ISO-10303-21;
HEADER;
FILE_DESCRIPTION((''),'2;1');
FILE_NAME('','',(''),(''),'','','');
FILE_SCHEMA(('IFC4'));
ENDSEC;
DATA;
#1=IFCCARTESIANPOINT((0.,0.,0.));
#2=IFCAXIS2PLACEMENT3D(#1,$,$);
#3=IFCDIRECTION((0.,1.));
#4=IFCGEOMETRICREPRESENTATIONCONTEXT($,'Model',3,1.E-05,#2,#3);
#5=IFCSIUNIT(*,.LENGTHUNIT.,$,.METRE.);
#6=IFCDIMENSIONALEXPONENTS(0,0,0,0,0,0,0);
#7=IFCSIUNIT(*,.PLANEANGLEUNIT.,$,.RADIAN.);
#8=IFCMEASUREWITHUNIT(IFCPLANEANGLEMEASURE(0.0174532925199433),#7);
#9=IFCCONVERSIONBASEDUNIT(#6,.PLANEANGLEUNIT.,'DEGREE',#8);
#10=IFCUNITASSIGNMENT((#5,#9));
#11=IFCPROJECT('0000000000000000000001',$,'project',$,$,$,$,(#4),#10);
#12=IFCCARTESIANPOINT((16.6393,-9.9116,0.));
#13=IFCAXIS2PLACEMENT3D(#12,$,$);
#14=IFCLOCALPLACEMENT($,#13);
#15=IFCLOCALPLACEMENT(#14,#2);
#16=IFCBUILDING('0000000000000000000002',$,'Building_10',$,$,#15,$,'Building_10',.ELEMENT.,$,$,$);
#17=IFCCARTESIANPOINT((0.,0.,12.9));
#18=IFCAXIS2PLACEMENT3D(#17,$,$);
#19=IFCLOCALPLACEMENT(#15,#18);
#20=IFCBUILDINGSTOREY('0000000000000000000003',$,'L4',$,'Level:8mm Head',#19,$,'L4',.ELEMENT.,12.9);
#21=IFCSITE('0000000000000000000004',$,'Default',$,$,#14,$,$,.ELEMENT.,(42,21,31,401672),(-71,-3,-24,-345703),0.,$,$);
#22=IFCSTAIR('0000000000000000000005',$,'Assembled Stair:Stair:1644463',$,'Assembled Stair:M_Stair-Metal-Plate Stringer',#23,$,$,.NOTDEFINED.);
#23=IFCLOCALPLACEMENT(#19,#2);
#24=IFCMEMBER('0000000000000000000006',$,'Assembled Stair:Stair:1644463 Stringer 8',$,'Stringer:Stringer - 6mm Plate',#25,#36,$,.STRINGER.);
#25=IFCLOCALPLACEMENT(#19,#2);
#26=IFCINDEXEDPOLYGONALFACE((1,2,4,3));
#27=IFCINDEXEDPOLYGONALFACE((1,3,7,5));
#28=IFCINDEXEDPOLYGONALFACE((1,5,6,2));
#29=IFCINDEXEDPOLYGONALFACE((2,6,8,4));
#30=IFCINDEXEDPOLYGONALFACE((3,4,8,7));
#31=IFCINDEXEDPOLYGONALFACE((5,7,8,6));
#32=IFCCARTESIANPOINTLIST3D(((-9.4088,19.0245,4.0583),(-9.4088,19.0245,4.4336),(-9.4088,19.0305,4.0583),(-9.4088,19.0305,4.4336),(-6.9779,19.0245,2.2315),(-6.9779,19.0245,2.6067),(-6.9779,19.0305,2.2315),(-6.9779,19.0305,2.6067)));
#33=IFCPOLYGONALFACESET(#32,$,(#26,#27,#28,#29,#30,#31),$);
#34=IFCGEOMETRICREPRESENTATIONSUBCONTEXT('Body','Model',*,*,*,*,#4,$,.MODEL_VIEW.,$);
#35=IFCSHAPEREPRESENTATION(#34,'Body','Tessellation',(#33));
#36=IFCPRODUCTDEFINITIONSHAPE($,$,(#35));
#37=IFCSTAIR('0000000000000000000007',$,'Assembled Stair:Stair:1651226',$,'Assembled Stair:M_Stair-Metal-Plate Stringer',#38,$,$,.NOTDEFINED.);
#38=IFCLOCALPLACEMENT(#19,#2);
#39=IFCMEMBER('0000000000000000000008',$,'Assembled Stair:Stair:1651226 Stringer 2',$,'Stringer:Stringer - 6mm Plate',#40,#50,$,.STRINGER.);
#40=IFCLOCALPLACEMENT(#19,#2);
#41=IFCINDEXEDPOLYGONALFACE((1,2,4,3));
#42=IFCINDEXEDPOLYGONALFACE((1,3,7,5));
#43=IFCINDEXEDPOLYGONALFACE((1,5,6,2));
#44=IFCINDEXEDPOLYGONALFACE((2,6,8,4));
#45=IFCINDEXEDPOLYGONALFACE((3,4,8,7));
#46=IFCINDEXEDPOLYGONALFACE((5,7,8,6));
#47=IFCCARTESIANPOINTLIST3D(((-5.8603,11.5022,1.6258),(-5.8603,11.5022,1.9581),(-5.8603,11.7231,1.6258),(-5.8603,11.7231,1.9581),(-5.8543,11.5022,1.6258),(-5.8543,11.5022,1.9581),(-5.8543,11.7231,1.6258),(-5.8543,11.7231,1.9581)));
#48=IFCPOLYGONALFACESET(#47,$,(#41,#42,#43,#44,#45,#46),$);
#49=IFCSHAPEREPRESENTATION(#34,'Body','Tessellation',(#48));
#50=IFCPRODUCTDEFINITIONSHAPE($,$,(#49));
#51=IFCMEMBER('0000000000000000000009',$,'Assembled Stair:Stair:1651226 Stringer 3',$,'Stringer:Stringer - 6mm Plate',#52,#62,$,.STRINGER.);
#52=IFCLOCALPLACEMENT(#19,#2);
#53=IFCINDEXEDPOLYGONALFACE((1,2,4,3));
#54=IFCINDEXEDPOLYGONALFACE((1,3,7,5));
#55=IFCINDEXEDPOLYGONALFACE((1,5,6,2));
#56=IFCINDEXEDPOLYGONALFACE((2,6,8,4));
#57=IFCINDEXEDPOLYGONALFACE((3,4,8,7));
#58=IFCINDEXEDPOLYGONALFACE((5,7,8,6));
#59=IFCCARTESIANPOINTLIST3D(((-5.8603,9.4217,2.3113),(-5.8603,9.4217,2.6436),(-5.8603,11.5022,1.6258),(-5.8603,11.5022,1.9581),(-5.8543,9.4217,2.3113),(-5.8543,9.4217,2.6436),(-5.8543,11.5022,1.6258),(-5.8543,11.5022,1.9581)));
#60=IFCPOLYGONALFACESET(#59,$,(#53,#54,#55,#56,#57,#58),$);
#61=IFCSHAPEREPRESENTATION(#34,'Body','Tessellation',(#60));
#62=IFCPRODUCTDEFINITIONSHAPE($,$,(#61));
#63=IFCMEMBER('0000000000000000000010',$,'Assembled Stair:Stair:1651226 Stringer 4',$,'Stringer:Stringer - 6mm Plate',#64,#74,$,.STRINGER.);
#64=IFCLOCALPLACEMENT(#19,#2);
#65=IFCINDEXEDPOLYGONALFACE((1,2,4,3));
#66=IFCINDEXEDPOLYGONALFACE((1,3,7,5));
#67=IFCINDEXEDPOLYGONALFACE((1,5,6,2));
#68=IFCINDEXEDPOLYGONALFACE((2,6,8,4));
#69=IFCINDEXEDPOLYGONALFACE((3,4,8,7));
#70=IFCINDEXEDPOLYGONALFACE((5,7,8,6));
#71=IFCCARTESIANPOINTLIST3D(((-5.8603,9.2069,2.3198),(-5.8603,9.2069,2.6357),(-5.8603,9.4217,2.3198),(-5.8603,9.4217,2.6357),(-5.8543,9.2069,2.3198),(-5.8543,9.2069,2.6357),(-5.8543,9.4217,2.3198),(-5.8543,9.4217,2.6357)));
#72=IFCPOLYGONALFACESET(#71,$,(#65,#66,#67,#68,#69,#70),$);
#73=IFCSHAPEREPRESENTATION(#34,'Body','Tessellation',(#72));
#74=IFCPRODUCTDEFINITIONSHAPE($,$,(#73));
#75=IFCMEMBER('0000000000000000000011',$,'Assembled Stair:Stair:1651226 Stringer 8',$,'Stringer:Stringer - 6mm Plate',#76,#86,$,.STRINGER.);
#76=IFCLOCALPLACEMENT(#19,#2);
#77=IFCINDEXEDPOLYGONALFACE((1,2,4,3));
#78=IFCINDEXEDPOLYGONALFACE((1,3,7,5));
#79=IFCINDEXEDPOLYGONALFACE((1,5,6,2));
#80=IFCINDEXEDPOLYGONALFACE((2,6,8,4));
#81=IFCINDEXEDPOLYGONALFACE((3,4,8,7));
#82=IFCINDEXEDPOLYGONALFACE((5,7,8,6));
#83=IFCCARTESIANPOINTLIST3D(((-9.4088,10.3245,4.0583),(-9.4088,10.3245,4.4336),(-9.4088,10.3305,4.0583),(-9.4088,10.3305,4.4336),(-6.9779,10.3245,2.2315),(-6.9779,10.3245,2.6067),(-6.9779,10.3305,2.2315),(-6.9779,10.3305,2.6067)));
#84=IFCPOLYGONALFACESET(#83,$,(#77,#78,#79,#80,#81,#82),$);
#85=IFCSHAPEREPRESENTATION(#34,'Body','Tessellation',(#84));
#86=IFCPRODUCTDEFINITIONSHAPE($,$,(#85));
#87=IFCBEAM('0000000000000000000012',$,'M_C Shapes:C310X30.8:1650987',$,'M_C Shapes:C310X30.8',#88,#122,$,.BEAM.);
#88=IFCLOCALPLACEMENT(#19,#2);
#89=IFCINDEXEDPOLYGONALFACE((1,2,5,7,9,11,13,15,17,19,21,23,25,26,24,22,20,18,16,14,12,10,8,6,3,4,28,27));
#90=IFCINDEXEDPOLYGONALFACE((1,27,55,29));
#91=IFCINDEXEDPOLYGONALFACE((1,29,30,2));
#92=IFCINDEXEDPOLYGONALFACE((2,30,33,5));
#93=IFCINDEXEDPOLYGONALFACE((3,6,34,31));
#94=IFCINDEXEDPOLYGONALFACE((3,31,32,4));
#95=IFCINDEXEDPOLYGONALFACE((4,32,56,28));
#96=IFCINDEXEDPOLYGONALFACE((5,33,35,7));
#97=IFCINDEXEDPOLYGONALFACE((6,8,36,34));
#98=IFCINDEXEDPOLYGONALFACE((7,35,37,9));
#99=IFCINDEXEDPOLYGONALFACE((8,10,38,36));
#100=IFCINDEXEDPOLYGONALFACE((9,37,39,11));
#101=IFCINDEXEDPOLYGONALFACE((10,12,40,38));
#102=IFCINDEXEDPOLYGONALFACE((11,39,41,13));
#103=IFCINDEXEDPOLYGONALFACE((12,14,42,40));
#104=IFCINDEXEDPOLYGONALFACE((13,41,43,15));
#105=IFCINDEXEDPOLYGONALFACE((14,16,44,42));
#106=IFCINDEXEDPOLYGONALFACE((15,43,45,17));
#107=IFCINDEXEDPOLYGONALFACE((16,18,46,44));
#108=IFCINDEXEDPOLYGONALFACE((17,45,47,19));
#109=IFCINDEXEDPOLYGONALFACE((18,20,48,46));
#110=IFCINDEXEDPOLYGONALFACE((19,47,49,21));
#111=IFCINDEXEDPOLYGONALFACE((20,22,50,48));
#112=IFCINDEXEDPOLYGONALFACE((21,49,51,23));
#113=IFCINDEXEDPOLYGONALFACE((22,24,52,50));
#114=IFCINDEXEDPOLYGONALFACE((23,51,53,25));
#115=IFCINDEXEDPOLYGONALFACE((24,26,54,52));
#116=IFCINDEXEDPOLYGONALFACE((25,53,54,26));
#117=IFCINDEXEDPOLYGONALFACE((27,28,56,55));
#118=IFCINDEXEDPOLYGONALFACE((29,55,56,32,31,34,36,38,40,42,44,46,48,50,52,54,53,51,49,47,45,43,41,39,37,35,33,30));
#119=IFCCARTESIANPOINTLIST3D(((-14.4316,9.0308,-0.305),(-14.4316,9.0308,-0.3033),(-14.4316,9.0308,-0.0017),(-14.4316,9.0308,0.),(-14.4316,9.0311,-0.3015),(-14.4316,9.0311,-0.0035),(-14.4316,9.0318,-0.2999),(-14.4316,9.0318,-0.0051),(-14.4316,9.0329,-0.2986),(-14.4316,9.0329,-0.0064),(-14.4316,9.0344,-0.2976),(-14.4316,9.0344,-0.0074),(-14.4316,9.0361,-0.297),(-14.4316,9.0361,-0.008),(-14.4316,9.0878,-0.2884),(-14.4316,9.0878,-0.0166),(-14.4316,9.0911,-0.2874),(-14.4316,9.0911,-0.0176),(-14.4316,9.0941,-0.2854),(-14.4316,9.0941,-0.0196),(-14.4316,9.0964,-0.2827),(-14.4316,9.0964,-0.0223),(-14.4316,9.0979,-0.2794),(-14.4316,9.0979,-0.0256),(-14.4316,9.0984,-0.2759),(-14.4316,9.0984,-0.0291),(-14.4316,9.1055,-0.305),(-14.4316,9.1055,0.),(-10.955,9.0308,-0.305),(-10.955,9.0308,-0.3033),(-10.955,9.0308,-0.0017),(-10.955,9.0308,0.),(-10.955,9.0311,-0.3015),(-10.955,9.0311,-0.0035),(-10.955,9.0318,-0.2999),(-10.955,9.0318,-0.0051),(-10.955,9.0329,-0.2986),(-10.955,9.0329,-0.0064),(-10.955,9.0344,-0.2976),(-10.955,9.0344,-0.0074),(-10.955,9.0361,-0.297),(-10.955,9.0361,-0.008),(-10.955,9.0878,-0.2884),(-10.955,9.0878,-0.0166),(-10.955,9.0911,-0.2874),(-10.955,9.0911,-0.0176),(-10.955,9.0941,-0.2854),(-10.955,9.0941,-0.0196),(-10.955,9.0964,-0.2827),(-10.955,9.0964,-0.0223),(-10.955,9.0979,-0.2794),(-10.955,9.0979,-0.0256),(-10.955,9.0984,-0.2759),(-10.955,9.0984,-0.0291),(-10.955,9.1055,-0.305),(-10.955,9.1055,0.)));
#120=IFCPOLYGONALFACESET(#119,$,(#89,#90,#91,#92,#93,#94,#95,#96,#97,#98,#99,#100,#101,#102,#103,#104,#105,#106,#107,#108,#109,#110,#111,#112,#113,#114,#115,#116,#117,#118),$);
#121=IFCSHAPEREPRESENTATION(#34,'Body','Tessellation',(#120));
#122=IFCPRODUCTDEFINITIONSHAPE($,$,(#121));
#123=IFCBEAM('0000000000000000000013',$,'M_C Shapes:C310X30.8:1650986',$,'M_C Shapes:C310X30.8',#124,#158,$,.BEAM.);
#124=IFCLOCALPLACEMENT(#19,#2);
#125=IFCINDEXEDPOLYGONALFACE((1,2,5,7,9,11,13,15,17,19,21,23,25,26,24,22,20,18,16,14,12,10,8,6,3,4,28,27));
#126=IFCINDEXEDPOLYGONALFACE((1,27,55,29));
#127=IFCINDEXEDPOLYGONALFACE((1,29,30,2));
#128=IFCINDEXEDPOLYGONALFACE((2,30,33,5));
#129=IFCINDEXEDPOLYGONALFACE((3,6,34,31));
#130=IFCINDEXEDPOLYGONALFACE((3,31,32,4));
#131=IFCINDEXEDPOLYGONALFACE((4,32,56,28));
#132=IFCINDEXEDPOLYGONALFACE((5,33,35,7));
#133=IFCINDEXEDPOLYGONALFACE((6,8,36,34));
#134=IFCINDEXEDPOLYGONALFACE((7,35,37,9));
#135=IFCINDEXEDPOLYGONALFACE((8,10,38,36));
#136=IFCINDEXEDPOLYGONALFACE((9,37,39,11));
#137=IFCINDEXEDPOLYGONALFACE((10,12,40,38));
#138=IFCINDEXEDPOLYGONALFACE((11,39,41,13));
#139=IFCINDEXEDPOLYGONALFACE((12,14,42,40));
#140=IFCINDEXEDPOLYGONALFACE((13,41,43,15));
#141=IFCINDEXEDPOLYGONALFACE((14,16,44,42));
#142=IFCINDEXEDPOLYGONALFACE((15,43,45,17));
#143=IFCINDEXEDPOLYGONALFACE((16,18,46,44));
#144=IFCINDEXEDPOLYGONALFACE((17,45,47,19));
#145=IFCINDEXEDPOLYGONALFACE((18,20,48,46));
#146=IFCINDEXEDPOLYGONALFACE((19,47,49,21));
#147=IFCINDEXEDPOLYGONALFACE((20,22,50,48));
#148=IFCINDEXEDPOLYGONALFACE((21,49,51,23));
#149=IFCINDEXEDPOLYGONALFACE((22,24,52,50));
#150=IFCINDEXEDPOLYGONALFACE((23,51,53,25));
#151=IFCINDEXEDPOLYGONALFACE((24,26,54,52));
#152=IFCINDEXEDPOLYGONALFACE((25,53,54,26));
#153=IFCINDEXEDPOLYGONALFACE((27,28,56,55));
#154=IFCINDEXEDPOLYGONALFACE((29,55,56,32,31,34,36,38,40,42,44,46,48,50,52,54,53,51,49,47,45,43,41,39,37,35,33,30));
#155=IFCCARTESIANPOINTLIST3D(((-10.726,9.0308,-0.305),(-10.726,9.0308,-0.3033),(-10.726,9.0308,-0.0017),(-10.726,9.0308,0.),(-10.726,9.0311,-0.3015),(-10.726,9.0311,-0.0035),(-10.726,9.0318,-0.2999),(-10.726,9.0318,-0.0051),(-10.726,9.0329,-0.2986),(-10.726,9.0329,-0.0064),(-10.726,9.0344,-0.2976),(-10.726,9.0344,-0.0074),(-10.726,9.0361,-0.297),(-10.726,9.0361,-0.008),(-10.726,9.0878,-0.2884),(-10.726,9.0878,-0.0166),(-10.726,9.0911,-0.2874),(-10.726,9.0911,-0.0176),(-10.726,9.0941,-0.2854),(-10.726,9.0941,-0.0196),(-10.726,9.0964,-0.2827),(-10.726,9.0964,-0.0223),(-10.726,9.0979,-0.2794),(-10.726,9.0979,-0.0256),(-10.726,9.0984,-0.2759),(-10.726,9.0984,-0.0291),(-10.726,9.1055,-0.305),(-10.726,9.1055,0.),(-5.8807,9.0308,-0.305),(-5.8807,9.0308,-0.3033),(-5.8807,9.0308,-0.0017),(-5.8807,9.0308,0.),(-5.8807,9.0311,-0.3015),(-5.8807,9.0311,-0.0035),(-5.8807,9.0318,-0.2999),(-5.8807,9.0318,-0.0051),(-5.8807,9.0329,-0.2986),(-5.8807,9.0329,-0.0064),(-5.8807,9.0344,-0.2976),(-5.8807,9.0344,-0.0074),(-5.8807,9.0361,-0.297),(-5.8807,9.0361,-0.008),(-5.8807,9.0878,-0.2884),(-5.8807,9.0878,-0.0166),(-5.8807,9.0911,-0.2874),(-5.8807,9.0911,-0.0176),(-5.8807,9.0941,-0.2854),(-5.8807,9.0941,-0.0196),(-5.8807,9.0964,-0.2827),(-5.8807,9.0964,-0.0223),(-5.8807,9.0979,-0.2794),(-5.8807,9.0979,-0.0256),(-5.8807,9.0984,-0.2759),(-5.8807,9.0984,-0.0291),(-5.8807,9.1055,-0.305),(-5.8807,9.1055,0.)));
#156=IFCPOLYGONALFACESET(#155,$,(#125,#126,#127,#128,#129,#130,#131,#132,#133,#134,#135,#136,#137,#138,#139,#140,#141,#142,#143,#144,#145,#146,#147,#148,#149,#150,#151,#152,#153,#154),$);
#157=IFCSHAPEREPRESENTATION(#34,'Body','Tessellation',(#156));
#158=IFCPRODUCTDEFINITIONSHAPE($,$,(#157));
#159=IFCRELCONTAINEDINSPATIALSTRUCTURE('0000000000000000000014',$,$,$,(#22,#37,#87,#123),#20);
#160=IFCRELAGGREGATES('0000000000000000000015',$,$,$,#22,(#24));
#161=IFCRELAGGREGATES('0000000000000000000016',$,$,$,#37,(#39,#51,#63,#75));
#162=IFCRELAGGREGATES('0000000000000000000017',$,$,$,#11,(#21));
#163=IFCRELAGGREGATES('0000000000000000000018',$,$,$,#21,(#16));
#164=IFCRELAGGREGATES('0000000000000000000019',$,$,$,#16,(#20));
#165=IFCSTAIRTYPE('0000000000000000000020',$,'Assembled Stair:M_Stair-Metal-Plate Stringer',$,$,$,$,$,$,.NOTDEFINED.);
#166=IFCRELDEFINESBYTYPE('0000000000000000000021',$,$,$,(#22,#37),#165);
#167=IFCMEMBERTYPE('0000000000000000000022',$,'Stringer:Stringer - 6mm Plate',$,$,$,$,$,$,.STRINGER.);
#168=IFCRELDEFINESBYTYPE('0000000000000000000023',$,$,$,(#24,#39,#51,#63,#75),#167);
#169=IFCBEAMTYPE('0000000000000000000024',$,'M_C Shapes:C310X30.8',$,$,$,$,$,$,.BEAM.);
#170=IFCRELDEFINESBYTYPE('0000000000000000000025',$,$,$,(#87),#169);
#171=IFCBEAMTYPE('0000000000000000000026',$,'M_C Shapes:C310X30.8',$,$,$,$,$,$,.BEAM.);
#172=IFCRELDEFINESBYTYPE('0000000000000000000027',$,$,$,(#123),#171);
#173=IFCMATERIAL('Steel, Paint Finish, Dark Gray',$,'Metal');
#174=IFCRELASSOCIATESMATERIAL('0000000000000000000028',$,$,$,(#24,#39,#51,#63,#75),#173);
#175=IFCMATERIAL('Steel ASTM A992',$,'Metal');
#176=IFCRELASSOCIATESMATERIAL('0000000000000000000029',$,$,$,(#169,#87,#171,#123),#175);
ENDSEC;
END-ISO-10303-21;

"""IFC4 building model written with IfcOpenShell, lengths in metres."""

from ifc_helpers import new_model, entity, si_unit, converted_unit, direction, frame, origin, place, context, subcontext, project, spatial, line, arc, indexed_curve, outline, extrude, source, transform, mapped, material, type_object, type_shapes, element, aggregate, save


model = new_model("IFC4")

# Units and contexts
model_context = context("Model", 3, precision=1e-05, world=origin(), true_north=direction((0.0, 1.0)))
body_context = subcontext(model_context, "Body", "Model", "MODEL_VIEW")
ifc_project = project(units=[si_unit("LENGTHUNIT", "METRE"), converted_unit("PLANEANGLEUNIT", "DEGREE", entity("IfcPlaneAngleMeasure", 0.0174532925199433), si_unit("PLANEANGLEUNIT", "RADIAN"), dimensions=[0, 0, 0, 0, 0, 0, 0])], contexts=[model_context])

# Site, building, storey
site_placement = place(None, frame((16.6393, -9.9116, 0.0)))
site = spatial("IfcSite", under=ifc_project, at=site_placement, Name="Default", CompositionType="ELEMENT", RefLatitude=(42, 21, 31, 401672), RefLongitude=(-71, -3, -24, -345703), RefElevation=0.0)
building_placement = place(site_placement, origin())
building = spatial("IfcBuilding", under=site, at=building_placement, Name="Building_10", LongName="Building_10", CompositionType="ELEMENT")
storey_placement = place(building_placement, frame((0.0, 0.0, 12.9)))
storey = spatial("IfcBuildingStorey", under=building, at=storey_placement, Name="L4", ObjectType="Level:8mm Head", LongName="L4", CompositionType="ELEMENT", Elevation=12.9)

# Shared definitions
ifc_material_1 = material(Name="Steel ASTM A992", Category="Metal")

# Stairs, members
stair_type = type_object("IfcStairType", Name="Assembled Stair:M_Stair-Metal-Plate Stringer", PredefinedType="NOTDEFINED")
stair_1_placement = place(storey_placement, origin())
stair_1 = element("IfcStair", 1, at=stair_1_placement, inside=storey, type_object=stair_type, Name="Assembled Stair:Stair:1644463", ObjectType="Assembled Stair:M_Stair-Metal-Plate Stringer", PredefinedType="NOTDEFINED")
ifc_material_2 = material(Name="Steel, Paint Finish, Dark Gray", Category="Metal")
member_type = type_object("IfcMemberType", Name="Stringer:Stringer - 6mm Plate", PredefinedType="STRINGER")
member_1_placement = place(stair_1_placement, origin())
member_1 = element("IfcMember", 2, at=member_1_placement, type_object=member_type, material=ifc_material_2, Name="Assembled Stair:Stair:1644463 Stringer 8", ObjectType="Stringer:Stringer - 6mm Plate", PredefinedType="STRINGER", context=body_context, shape_type="SweptSolid", body=[
    extrude(outline(indexed_curve([(-1.6331, -0.15), (1.4077, -0.15), (1.6331, 0.15), (-1.4077, 0.15), (-1.6331, -0.15)], self_intersect=False)), frame((-8.1933, 19.0245, 3.3325), z_axis=(0.0, 1.0, 0.0), x_axis=(-0.799415, 0.0, 0.600779)), (0.0, 0.0, 1.0), 0.006),
])
aggregate(stair_1, [member_1])
stair_2_placement = place(storey_placement, origin())
stair_2 = element("IfcStair", 3, at=stair_2_placement, inside=storey, type_object=stair_type, Name="Assembled Stair:Stair:1651226", ObjectType="Assembled Stair:M_Stair-Metal-Plate Stringer", PredefinedType="NOTDEFINED")
member_2_placement = place(stair_2_placement, origin())
member_2 = element("IfcMember", 4, at=member_2_placement, type_object=member_type, material=ifc_material_2, Name="Assembled Stair:Stair:1651226 Stringer 2", ObjectType="Stringer:Stringer - 6mm Plate", PredefinedType="STRINGER", context=body_context, shape_type="SweptSolid", body=[
    extrude(outline(indexed_curve([(-0.1104, -0.003), (0.1104, -0.003), (0.1104, 0.003), (-0.1104, 0.003), (-0.1104, -0.003)], self_intersect=False)), frame((-5.8573, 11.6126, 1.6258), z_axis=(0.0, 0.0, 1.0), x_axis=(0.0, -1.0, 0.0)), (0.0, 0.0, 1.0), 0.3323),
])
member_3_placement = place(stair_2_placement, origin())
member_3 = element("IfcMember", 5, at=member_3_placement, type_object=member_type, material=ifc_material_2, Name="Assembled Stair:Stair:1651226 Stringer 3", ObjectType="Stringer:Stringer - 6mm Plate", PredefinedType="STRINGER", context=body_context, shape_type="SweptSolid", body=[
    extrude(outline(indexed_curve([(-1.0433, -0.1578), (1.1473, -0.1578), (1.0433, 0.1578), (-1.1473, 0.1578), (-1.0433, -0.1578)], self_intersect=False)), frame((-5.8603, 10.462, 2.1347), z_axis=(1.0, 0.0, 0.0), x_axis=(0.0, -0.949774, 0.312936)), (0.0, 0.0, 1.0), 0.006),
])
member_4_placement = place(stair_2_placement, origin())
member_4 = element("IfcMember", 6, at=member_4_placement, type_object=member_type, material=ifc_material_2, Name="Assembled Stair:Stair:1651226 Stringer 4", ObjectType="Stringer:Stringer - 6mm Plate", PredefinedType="STRINGER", context=body_context, shape_type="SweptSolid", body=[
    extrude(outline(indexed_curve([(-0.1074, -0.003), (0.1074, -0.003), (0.1074, 0.003), (-0.1074, 0.003), (-0.1074, -0.003)], self_intersect=False)), frame((-5.8573, 9.3143, 2.3198), z_axis=(0.0, 0.0, 1.0), x_axis=(0.0, -1.0, 0.0)), (0.0, 0.0, 1.0), 0.3159),
])
member_5_placement = place(stair_2_placement, origin())
member_5 = element("IfcMember", 7, at=member_5_placement, type_object=member_type, material=ifc_material_2, Name="Assembled Stair:Stair:1651226 Stringer 8", ObjectType="Stringer:Stringer - 6mm Plate", PredefinedType="STRINGER", context=body_context, shape_type="SweptSolid", body=[
    extrude(outline(indexed_curve([(-1.6331, -0.15), (1.4077, -0.15), (1.6331, 0.15), (-1.4077, 0.15), (-1.6331, -0.15)], self_intersect=False)), frame((-8.1933, 10.3245, 3.3325), z_axis=(0.0, 1.0, 0.0), x_axis=(-0.799415, 0.0, 0.600779)), (0.0, 0.0, 1.0), 0.006),
])
aggregate(stair_2, [member_2, member_3, member_4, member_5])

# Beams
beam_type_1 = type_object("IfcBeamType", Name="M_C Shapes:C310X30.8", PredefinedType="BEAM", material=ifc_material_1)
shared_shape_1 = source(origin(), body_context, "Body", "SweptSolid", [
    extrude(outline(indexed_curve([(-0.0406, -0.1525), (0.0341, -0.1525), (0.0341, -0.1508), (0.0326, -0.1467), (0.0288, -0.1445), (-0.0228, -0.1359), (-0.0305, -0.1316), (-0.0335, -0.1234), (-0.0335, 0.1234), (-0.0305, 0.1316), (-0.0228, 0.1359), (0.0288, 0.1445), (0.0326, 0.1467), (0.0341, 0.1508), (0.0341, 0.1525), (-0.0406, 0.1525)], segments=[line(1, 2, 3), arc(3, 4, 5), line(5, 6), arc(6, 7, 8), line(8, 9), arc(9, 10, 11), line(11, 12), arc(12, 13, 14), line(14, 15, 16, 1)], self_intersect=False)), frame((-1.7383, -0.0229, 0.0), z_axis=(1.0, 0.0, 0.0), x_axis=(0.0, -1.0, 0.0)), (0.0, 0.0, 1.0), 3.4766),
])
type_shapes(beam_type_1, [shared_shape_1])
beam_1_placement = place(storey_placement, frame((-12.6933, 9.0878, -0.1525)))
element("IfcBeam", 8, at=beam_1_placement, inside=storey, type_object=beam_type_1, material=ifc_material_1, Name="M_C Shapes:C310X30.8:1650987", ObjectType="M_C Shapes:C310X30.8", PredefinedType="BEAM", context=body_context, shape_type="MappedRepresentation", body=[
    mapped(shared_shape_1, transform((0.0, 0.0, 0.0), scale=1.0)),
])
beam_type_2 = type_object("IfcBeamType", Name="M_C Shapes:C310X30.8", PredefinedType="BEAM", material=ifc_material_1)
shared_shape_2 = source(origin(), body_context, "Body", "SweptSolid", [
    extrude(outline(indexed_curve([(-0.0406, -0.1525), (0.0341, -0.1525), (0.0341, -0.1508), (0.0326, -0.1467), (0.0288, -0.1445), (-0.0228, -0.1359), (-0.0305, -0.1316), (-0.0335, -0.1234), (-0.0335, 0.1234), (-0.0305, 0.1316), (-0.0228, 0.1359), (0.0288, 0.1445), (0.0326, 0.1467), (0.0341, 0.1508), (0.0341, 0.1525), (-0.0406, 0.1525)], segments=[line(1, 2, 3), arc(3, 4, 5), line(5, 6), arc(6, 7, 8), line(8, 9), arc(9, 10, 11), line(11, 12), arc(12, 13, 14), line(14, 15, 16, 1)], self_intersect=False)), frame((-2.4226, -0.0229, 0.0), z_axis=(1.0, 0.0, 0.0), x_axis=(0.0, -1.0, 0.0)), (0.0, 0.0, 1.0), 4.8453),
])
type_shapes(beam_type_2, [shared_shape_2])
beam_2_placement = place(storey_placement, frame((-8.3033, 9.0878, -0.1525)))
element("IfcBeam", 9, at=beam_2_placement, inside=storey, type_object=beam_type_2, material=ifc_material_1, Name="M_C Shapes:C310X30.8:1650986", ObjectType="M_C Shapes:C310X30.8", PredefinedType="BEAM", context=body_context, shape_type="MappedRepresentation", body=[
    mapped(shared_shape_2, transform((0.0, 0.0, 0.0), scale=1.0)),
])

save(model, "model.ifc")
